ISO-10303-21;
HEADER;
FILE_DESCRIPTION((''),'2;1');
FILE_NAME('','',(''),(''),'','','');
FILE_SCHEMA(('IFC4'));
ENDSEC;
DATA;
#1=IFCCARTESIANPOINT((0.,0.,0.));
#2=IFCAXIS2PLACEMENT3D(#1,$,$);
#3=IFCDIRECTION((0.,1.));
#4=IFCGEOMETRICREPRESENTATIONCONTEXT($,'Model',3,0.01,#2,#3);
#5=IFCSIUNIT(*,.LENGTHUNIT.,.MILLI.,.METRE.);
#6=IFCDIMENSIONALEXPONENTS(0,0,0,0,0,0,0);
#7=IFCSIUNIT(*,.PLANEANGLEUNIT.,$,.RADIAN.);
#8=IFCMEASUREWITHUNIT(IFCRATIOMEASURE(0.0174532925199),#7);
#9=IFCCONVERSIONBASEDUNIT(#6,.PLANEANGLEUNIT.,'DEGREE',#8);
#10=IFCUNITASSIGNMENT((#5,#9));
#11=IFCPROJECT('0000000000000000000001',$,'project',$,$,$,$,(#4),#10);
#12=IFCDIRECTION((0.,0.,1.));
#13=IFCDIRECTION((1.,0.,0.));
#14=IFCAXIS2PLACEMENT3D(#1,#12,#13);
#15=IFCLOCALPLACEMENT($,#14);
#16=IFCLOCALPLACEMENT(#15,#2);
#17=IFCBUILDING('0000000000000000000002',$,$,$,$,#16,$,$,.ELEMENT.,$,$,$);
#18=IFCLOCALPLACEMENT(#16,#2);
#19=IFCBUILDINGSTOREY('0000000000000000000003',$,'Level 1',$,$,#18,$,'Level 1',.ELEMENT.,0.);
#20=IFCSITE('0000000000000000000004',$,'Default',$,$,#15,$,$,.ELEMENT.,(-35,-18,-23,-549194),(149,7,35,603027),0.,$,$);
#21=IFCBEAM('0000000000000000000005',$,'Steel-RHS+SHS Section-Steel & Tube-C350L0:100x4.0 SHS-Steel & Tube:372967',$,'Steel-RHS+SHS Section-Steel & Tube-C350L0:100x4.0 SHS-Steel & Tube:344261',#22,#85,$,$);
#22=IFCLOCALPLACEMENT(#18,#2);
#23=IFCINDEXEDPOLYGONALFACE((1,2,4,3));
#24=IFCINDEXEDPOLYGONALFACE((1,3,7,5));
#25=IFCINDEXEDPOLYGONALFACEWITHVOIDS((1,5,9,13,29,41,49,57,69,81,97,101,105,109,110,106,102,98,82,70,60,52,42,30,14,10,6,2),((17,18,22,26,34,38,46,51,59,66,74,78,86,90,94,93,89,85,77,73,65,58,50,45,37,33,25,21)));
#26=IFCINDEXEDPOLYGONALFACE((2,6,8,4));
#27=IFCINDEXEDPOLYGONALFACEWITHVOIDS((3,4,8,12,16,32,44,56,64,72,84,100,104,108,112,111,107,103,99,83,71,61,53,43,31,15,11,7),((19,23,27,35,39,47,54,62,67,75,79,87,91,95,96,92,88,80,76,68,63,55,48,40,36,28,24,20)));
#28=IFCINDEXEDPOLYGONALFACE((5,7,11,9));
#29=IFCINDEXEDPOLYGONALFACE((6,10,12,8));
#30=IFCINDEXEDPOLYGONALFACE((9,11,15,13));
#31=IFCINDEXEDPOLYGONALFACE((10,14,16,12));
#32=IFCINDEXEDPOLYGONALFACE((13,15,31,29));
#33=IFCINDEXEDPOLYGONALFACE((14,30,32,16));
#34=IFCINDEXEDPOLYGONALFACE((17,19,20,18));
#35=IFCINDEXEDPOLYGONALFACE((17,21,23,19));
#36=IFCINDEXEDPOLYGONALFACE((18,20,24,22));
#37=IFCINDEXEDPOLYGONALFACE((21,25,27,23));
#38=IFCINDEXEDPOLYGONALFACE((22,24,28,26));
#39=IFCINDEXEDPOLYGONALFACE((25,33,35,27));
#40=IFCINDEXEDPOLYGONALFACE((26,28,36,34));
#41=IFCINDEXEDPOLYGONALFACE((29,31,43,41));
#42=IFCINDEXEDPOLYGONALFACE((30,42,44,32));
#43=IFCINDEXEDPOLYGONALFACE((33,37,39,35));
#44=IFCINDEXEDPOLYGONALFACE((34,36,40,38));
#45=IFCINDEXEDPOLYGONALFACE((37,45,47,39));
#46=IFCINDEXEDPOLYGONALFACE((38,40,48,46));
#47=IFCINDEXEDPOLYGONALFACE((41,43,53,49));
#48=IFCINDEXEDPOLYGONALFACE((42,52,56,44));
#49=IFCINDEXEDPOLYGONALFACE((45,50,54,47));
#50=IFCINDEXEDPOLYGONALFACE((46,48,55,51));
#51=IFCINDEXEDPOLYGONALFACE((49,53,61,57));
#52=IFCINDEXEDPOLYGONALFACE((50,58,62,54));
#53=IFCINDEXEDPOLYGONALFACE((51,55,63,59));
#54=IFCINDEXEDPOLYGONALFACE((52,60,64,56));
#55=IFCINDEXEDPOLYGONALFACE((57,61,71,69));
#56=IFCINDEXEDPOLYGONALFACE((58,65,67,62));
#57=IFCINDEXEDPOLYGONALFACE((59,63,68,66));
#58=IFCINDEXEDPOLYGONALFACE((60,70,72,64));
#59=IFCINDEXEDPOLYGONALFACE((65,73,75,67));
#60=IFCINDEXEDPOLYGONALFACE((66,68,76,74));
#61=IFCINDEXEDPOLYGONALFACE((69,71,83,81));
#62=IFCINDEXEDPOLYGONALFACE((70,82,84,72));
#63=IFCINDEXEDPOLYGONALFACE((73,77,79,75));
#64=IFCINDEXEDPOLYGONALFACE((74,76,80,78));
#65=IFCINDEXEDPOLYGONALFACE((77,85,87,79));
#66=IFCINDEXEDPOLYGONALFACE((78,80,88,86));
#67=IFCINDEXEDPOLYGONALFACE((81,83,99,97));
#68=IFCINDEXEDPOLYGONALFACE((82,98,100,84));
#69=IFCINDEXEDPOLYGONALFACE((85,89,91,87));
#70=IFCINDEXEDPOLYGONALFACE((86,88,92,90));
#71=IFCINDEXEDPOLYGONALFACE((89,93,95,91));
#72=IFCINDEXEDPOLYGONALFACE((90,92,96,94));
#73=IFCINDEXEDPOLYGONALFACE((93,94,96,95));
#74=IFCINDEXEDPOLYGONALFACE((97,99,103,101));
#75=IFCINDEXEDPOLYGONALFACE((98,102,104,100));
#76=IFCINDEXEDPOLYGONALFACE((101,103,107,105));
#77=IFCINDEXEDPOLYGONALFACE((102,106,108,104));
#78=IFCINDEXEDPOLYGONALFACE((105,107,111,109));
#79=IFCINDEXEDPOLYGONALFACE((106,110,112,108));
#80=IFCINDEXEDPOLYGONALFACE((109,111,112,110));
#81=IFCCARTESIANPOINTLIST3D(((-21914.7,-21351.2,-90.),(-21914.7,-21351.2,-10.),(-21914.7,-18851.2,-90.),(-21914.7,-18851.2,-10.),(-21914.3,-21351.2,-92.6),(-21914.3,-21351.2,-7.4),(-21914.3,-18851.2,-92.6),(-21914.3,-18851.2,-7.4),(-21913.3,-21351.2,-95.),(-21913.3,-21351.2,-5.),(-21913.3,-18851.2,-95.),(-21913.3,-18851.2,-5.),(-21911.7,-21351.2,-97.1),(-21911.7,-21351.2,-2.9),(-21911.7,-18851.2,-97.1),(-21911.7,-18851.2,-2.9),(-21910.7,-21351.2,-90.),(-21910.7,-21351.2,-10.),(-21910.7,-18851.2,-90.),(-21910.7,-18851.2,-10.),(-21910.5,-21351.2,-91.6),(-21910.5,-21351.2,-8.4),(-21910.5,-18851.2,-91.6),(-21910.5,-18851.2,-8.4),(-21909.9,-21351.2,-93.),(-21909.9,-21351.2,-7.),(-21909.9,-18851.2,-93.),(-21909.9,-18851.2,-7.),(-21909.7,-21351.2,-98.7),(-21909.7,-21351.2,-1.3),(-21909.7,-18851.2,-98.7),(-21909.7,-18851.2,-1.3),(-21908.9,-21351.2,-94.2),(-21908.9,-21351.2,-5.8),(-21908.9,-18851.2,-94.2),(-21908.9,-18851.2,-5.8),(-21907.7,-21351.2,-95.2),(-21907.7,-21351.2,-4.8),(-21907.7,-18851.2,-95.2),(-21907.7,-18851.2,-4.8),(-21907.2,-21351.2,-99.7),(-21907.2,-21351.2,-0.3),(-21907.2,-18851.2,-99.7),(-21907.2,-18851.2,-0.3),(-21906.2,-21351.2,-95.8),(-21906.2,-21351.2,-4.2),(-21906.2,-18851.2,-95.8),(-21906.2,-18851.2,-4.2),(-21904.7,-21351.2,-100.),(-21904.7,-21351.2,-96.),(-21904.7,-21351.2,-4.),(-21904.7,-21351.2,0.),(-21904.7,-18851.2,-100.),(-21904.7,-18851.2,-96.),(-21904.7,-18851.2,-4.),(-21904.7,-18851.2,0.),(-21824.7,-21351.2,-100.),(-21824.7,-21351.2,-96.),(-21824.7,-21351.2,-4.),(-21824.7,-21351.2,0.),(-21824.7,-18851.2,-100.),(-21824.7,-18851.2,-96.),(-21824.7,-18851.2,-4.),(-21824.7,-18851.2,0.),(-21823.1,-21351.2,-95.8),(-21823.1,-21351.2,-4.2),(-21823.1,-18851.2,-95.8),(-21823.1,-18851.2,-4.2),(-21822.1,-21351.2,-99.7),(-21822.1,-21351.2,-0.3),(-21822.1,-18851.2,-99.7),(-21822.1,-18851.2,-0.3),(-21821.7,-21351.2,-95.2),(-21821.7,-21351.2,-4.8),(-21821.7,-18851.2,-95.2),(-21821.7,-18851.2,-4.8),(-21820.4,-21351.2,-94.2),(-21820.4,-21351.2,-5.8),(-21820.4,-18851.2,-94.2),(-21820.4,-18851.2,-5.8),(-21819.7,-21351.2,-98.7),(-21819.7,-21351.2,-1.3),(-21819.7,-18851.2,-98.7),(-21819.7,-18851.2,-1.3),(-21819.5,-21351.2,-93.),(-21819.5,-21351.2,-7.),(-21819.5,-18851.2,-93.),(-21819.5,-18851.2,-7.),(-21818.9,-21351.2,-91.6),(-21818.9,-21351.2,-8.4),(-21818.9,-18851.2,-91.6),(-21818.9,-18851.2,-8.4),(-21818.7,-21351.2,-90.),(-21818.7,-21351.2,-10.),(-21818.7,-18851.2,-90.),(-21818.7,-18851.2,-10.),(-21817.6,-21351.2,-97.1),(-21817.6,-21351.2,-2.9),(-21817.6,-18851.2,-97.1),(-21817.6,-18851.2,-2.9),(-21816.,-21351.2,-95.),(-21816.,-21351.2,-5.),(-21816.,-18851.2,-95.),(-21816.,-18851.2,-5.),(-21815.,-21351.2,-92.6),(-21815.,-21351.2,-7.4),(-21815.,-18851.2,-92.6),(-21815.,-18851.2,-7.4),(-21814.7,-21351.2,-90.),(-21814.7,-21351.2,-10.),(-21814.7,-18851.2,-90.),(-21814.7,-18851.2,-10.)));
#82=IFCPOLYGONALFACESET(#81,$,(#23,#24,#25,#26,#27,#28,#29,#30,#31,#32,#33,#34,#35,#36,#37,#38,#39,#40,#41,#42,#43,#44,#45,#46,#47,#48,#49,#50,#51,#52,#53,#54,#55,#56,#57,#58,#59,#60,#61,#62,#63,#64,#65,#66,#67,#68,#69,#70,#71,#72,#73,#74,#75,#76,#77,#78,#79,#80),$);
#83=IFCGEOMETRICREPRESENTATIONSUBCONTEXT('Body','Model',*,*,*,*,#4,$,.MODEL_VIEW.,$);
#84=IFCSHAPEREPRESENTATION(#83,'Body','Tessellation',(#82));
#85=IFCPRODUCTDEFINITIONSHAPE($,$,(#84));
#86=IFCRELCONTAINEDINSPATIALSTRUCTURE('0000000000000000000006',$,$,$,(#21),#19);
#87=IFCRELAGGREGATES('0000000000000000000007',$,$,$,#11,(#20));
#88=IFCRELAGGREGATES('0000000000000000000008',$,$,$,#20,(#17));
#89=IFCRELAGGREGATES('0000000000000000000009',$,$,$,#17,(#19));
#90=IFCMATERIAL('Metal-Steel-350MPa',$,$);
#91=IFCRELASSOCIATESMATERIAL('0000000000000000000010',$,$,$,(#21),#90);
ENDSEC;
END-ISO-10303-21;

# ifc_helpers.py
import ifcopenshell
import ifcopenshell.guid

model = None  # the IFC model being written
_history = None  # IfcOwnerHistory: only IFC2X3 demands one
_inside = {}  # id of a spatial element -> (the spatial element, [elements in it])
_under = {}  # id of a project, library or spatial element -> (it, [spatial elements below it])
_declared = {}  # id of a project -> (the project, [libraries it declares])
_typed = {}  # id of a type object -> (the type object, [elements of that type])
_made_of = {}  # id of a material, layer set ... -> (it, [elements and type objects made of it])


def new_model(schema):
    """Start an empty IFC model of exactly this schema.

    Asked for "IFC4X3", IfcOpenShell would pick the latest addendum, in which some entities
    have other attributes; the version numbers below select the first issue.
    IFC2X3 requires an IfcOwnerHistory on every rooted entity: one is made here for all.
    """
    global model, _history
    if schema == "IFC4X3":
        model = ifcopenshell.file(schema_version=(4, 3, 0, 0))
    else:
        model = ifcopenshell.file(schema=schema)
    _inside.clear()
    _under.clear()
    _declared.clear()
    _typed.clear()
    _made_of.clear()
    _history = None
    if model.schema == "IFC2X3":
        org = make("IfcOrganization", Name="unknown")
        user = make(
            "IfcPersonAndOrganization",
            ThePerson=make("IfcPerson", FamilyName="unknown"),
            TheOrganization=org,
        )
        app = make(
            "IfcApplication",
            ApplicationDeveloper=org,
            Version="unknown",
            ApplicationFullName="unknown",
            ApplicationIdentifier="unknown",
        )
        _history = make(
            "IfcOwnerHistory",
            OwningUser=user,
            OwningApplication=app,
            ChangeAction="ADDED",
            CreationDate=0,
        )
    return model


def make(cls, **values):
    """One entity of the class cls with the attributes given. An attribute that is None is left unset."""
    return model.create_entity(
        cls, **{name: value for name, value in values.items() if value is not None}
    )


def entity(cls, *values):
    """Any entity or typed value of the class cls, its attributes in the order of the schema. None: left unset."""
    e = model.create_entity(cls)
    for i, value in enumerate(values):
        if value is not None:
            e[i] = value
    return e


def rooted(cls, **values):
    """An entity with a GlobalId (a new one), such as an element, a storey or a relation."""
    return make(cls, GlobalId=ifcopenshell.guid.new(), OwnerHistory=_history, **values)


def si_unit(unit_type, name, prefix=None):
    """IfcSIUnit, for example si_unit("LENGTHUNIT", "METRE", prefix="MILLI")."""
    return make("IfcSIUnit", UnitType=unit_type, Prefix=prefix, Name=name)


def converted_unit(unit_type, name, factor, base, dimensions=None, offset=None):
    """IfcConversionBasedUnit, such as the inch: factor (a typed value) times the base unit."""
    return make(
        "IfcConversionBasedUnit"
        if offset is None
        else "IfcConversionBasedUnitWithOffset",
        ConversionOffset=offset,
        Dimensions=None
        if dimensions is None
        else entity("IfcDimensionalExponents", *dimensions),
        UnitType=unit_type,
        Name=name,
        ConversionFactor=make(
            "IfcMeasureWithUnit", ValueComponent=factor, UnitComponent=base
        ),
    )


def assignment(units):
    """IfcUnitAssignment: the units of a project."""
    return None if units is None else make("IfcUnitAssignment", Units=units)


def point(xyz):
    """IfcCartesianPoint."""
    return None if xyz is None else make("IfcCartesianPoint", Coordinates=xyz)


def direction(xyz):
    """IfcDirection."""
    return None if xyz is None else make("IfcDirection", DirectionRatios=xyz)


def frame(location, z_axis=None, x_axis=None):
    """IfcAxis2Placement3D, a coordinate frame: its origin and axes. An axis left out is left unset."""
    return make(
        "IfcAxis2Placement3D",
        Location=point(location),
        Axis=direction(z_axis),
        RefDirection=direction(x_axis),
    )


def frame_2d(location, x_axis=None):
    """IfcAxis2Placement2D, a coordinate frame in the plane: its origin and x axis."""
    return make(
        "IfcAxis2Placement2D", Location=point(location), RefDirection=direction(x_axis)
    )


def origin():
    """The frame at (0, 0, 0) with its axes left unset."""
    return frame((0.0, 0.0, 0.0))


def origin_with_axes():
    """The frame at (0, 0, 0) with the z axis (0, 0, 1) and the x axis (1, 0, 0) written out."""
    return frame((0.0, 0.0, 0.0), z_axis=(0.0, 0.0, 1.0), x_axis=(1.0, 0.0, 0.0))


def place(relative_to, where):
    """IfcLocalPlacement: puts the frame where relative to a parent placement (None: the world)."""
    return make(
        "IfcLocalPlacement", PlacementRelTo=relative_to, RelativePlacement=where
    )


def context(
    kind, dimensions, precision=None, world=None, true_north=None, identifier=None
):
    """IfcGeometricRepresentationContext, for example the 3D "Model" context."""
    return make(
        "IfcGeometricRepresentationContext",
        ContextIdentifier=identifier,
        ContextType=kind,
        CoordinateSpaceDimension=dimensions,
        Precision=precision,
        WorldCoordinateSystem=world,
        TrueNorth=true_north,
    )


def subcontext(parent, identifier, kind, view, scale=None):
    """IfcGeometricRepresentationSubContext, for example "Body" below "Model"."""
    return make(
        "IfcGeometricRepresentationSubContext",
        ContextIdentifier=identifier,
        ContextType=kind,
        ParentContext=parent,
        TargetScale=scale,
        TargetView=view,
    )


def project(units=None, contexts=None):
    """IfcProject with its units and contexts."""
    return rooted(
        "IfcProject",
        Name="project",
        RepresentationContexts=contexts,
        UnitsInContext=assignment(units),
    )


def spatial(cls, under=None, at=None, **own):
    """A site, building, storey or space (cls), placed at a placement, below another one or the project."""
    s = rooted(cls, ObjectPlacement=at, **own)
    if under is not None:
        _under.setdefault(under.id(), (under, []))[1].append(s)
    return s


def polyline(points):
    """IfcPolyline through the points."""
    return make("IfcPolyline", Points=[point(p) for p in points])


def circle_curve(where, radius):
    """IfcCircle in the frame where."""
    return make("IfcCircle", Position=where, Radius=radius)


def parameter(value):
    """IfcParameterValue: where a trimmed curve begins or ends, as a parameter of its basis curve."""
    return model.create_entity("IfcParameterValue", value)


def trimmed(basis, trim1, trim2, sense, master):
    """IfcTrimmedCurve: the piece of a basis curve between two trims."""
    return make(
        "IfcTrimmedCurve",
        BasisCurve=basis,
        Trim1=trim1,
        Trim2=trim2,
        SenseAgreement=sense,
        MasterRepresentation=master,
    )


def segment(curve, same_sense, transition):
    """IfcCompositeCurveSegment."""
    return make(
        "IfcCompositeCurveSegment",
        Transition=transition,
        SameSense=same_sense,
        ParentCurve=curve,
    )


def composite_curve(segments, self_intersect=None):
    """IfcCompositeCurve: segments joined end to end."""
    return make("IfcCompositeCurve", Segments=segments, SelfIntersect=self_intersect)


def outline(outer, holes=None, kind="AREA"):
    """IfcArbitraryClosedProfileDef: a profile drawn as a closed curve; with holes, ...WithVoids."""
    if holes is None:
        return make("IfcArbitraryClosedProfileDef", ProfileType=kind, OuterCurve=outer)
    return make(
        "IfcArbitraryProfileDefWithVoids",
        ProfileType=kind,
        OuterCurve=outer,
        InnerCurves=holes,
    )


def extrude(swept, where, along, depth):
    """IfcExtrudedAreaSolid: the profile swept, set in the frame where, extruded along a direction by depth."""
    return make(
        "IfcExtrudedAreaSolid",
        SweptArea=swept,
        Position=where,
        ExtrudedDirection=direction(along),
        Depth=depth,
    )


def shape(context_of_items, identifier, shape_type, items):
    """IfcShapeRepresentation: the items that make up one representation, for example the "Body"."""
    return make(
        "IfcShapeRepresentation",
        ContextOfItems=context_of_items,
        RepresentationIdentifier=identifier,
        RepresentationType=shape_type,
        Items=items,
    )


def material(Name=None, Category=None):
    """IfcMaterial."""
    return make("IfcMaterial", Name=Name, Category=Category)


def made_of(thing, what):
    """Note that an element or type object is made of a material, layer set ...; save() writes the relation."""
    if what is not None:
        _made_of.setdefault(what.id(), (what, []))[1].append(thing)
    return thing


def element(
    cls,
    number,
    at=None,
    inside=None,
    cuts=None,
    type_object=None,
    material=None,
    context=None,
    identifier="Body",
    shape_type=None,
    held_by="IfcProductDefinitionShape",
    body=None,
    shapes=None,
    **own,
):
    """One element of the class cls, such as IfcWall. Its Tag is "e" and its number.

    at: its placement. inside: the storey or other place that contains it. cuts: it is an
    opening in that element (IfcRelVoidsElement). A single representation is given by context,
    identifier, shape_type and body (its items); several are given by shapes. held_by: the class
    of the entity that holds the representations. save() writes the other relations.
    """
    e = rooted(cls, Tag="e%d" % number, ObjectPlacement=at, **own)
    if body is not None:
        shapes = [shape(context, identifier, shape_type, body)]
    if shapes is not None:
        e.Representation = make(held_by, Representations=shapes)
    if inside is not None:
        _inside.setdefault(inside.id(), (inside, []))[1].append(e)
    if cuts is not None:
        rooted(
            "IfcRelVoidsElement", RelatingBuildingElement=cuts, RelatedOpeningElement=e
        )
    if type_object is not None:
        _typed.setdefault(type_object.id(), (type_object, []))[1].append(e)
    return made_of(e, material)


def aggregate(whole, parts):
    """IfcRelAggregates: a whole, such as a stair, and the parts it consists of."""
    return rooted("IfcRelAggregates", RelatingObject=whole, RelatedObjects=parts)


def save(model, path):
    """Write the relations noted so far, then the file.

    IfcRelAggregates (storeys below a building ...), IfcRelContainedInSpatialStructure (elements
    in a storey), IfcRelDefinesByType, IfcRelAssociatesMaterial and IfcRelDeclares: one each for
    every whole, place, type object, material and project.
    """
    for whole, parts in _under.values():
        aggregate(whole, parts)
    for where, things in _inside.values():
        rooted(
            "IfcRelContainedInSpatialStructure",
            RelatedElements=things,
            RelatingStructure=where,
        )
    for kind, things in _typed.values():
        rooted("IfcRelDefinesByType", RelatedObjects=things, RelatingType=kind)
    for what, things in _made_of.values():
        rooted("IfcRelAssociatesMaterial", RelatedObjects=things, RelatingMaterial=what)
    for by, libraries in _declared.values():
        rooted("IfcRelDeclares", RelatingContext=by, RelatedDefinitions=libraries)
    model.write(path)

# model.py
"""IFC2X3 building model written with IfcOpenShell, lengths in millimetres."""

from ifc_helpers import new_model, entity, si_unit, converted_unit, direction, frame, frame_2d, origin, origin_with_axes, place, context, subcontext, project, spatial, polyline, circle_curve, parameter, trimmed, segment, composite_curve, outline, extrude, material, element, save


model = new_model("IFC2X3")

# Units and contexts
model_context = context("Model", 3, precision=0.01, world=origin(), true_north=direction((0.0, 1.0)))
body_context = subcontext(model_context, "Body", "Model", "MODEL_VIEW")
ifc_project = project(units=[si_unit("LENGTHUNIT", "METRE", prefix="MILLI"), converted_unit("PLANEANGLEUNIT", "DEGREE", entity("IfcRatioMeasure", 0.0174532925199), si_unit("PLANEANGLEUNIT", "RADIAN"), dimensions=[0, 0, 0, 0, 0, 0, 0])], contexts=[model_context])

# Site, building, storey
site_placement = place(None, origin_with_axes())
site = spatial("IfcSite", under=ifc_project, at=site_placement, Name="Default", CompositionType="ELEMENT", RefLatitude=(-35, -18, -23, -549194), RefLongitude=(149, 7, 35, 603027), RefElevation=0.0)
building_placement = place(site_placement, origin())
building = spatial("IfcBuilding", under=site, at=building_placement, CompositionType="ELEMENT")
storey_placement = place(building_placement, origin())
storey = spatial("IfcBuildingStorey", under=building, at=storey_placement, Name="Level 1", LongName="Level 1", CompositionType="ELEMENT", Elevation=0.0)

# Beam
ifc_material = material(Name="Metal-Steel-350MPa")
beam_1_placement = place(storey_placement, frame((-21864.7, -18851.2, 0.0), z_axis=(0.0, 0.0, 1.0), x_axis=(0.0, -1.0, 0.0)))
element("IfcBeam", 1, at=beam_1_placement, inside=storey, material=ifc_material, Name="Steel-RHS+SHS Section-Steel & Tube-C350L0:100x4.0 SHS-Steel & Tube:372967", ObjectType="Steel-RHS+SHS Section-Steel & Tube-C350L0:100x4.0 SHS-Steel & Tube:344261", context=body_context, shape_type="SweptSolid", body=[
    extrude(outline(composite_curve([segment(trimmed(circle_curve(frame_2d((-40.0, -40.0), x_axis=(1.0, 0.0)), 10.0), [parameter(180.0)], [parameter(270.0)], True, "PARAMETER"), True, "CONTINUOUS"), segment(polyline([(-40.0, -50.0), (40.0, -50.0)]), True, "CONTINUOUS"), segment(trimmed(circle_curve(frame_2d((40.0, -40.0), x_axis=(1.0, 0.0)), 10.0), [parameter(270.0)], [parameter(0.0)], True, "PARAMETER"), True, "CONTINUOUS"), segment(polyline([(50.0, -40.0), (50.0, 40.0)]), True, "CONTINUOUS"), segment(trimmed(circle_curve(frame_2d((40.0, 40.0), x_axis=(1.0, 0.0)), 10.0), [parameter(0.0)], [parameter(90.0)], True, "PARAMETER"), True, "CONTINUOUS"), segment(polyline([(40.0, 50.0), (-40.0, 50.0)]), True, "CONTINUOUS"), segment(trimmed(circle_curve(frame_2d((-40.0, 40.0), x_axis=(1.0, 0.0)), 10.0), [parameter(90.0)], [parameter(180.0)], True, "PARAMETER"), True, "CONTINUOUS"), segment(polyline([(-50.0, 40.0), (-50.0, -40.0)]), True, "CONTINUOUS")], self_intersect=False), holes=[composite_curve([segment(polyline([(40.0, -46.0), (-40.0, -46.0)]), True, "CONTINUOUS"), segment(trimmed(circle_curve(frame_2d((-40.0, -40.0), x_axis=(1.0, 0.0)), 6.0), [parameter(180.0)], [parameter(270.0)], True, "PARAMETER"), False, "CONTINUOUS"), segment(polyline([(-46.0, -40.0), (-46.0, 40.0)]), True, "CONTINUOUS"), segment(trimmed(circle_curve(frame_2d((-40.0, 40.0), x_axis=(1.0, 0.0)), 6.0), [parameter(90.0)], [parameter(180.0)], True, "PARAMETER"), False, "CONTINUOUS"), segment(polyline([(-40.0, 46.0), (40.0, 46.0)]), True, "CONTINUOUS"), segment(trimmed(circle_curve(frame_2d((40.0, 40.0), x_axis=(1.0, 0.0)), 6.0), [parameter(360.0)], [parameter(90.0)], True, "PARAMETER"), False, "CONTINUOUS"), segment(polyline([(46.0, 40.0), (46.0, -40.0)]), True, "CONTINUOUS"), segment(trimmed(circle_curve(frame_2d((40.0, -40.0), x_axis=(1.0, 0.0)), 6.0), [parameter(270.0)], [parameter(0.0)], True, "PARAMETER"), False, "CONTINUOUS")], self_intersect=False)]), frame((0.0, 0.0, -50.0), z_axis=(1.0, 0.0, 0.0), x_axis=(0.0, -1.0, 0.0)), (0.0, 0.0, 1.0), 2500.0),
])

save(model, "model.ifc")
